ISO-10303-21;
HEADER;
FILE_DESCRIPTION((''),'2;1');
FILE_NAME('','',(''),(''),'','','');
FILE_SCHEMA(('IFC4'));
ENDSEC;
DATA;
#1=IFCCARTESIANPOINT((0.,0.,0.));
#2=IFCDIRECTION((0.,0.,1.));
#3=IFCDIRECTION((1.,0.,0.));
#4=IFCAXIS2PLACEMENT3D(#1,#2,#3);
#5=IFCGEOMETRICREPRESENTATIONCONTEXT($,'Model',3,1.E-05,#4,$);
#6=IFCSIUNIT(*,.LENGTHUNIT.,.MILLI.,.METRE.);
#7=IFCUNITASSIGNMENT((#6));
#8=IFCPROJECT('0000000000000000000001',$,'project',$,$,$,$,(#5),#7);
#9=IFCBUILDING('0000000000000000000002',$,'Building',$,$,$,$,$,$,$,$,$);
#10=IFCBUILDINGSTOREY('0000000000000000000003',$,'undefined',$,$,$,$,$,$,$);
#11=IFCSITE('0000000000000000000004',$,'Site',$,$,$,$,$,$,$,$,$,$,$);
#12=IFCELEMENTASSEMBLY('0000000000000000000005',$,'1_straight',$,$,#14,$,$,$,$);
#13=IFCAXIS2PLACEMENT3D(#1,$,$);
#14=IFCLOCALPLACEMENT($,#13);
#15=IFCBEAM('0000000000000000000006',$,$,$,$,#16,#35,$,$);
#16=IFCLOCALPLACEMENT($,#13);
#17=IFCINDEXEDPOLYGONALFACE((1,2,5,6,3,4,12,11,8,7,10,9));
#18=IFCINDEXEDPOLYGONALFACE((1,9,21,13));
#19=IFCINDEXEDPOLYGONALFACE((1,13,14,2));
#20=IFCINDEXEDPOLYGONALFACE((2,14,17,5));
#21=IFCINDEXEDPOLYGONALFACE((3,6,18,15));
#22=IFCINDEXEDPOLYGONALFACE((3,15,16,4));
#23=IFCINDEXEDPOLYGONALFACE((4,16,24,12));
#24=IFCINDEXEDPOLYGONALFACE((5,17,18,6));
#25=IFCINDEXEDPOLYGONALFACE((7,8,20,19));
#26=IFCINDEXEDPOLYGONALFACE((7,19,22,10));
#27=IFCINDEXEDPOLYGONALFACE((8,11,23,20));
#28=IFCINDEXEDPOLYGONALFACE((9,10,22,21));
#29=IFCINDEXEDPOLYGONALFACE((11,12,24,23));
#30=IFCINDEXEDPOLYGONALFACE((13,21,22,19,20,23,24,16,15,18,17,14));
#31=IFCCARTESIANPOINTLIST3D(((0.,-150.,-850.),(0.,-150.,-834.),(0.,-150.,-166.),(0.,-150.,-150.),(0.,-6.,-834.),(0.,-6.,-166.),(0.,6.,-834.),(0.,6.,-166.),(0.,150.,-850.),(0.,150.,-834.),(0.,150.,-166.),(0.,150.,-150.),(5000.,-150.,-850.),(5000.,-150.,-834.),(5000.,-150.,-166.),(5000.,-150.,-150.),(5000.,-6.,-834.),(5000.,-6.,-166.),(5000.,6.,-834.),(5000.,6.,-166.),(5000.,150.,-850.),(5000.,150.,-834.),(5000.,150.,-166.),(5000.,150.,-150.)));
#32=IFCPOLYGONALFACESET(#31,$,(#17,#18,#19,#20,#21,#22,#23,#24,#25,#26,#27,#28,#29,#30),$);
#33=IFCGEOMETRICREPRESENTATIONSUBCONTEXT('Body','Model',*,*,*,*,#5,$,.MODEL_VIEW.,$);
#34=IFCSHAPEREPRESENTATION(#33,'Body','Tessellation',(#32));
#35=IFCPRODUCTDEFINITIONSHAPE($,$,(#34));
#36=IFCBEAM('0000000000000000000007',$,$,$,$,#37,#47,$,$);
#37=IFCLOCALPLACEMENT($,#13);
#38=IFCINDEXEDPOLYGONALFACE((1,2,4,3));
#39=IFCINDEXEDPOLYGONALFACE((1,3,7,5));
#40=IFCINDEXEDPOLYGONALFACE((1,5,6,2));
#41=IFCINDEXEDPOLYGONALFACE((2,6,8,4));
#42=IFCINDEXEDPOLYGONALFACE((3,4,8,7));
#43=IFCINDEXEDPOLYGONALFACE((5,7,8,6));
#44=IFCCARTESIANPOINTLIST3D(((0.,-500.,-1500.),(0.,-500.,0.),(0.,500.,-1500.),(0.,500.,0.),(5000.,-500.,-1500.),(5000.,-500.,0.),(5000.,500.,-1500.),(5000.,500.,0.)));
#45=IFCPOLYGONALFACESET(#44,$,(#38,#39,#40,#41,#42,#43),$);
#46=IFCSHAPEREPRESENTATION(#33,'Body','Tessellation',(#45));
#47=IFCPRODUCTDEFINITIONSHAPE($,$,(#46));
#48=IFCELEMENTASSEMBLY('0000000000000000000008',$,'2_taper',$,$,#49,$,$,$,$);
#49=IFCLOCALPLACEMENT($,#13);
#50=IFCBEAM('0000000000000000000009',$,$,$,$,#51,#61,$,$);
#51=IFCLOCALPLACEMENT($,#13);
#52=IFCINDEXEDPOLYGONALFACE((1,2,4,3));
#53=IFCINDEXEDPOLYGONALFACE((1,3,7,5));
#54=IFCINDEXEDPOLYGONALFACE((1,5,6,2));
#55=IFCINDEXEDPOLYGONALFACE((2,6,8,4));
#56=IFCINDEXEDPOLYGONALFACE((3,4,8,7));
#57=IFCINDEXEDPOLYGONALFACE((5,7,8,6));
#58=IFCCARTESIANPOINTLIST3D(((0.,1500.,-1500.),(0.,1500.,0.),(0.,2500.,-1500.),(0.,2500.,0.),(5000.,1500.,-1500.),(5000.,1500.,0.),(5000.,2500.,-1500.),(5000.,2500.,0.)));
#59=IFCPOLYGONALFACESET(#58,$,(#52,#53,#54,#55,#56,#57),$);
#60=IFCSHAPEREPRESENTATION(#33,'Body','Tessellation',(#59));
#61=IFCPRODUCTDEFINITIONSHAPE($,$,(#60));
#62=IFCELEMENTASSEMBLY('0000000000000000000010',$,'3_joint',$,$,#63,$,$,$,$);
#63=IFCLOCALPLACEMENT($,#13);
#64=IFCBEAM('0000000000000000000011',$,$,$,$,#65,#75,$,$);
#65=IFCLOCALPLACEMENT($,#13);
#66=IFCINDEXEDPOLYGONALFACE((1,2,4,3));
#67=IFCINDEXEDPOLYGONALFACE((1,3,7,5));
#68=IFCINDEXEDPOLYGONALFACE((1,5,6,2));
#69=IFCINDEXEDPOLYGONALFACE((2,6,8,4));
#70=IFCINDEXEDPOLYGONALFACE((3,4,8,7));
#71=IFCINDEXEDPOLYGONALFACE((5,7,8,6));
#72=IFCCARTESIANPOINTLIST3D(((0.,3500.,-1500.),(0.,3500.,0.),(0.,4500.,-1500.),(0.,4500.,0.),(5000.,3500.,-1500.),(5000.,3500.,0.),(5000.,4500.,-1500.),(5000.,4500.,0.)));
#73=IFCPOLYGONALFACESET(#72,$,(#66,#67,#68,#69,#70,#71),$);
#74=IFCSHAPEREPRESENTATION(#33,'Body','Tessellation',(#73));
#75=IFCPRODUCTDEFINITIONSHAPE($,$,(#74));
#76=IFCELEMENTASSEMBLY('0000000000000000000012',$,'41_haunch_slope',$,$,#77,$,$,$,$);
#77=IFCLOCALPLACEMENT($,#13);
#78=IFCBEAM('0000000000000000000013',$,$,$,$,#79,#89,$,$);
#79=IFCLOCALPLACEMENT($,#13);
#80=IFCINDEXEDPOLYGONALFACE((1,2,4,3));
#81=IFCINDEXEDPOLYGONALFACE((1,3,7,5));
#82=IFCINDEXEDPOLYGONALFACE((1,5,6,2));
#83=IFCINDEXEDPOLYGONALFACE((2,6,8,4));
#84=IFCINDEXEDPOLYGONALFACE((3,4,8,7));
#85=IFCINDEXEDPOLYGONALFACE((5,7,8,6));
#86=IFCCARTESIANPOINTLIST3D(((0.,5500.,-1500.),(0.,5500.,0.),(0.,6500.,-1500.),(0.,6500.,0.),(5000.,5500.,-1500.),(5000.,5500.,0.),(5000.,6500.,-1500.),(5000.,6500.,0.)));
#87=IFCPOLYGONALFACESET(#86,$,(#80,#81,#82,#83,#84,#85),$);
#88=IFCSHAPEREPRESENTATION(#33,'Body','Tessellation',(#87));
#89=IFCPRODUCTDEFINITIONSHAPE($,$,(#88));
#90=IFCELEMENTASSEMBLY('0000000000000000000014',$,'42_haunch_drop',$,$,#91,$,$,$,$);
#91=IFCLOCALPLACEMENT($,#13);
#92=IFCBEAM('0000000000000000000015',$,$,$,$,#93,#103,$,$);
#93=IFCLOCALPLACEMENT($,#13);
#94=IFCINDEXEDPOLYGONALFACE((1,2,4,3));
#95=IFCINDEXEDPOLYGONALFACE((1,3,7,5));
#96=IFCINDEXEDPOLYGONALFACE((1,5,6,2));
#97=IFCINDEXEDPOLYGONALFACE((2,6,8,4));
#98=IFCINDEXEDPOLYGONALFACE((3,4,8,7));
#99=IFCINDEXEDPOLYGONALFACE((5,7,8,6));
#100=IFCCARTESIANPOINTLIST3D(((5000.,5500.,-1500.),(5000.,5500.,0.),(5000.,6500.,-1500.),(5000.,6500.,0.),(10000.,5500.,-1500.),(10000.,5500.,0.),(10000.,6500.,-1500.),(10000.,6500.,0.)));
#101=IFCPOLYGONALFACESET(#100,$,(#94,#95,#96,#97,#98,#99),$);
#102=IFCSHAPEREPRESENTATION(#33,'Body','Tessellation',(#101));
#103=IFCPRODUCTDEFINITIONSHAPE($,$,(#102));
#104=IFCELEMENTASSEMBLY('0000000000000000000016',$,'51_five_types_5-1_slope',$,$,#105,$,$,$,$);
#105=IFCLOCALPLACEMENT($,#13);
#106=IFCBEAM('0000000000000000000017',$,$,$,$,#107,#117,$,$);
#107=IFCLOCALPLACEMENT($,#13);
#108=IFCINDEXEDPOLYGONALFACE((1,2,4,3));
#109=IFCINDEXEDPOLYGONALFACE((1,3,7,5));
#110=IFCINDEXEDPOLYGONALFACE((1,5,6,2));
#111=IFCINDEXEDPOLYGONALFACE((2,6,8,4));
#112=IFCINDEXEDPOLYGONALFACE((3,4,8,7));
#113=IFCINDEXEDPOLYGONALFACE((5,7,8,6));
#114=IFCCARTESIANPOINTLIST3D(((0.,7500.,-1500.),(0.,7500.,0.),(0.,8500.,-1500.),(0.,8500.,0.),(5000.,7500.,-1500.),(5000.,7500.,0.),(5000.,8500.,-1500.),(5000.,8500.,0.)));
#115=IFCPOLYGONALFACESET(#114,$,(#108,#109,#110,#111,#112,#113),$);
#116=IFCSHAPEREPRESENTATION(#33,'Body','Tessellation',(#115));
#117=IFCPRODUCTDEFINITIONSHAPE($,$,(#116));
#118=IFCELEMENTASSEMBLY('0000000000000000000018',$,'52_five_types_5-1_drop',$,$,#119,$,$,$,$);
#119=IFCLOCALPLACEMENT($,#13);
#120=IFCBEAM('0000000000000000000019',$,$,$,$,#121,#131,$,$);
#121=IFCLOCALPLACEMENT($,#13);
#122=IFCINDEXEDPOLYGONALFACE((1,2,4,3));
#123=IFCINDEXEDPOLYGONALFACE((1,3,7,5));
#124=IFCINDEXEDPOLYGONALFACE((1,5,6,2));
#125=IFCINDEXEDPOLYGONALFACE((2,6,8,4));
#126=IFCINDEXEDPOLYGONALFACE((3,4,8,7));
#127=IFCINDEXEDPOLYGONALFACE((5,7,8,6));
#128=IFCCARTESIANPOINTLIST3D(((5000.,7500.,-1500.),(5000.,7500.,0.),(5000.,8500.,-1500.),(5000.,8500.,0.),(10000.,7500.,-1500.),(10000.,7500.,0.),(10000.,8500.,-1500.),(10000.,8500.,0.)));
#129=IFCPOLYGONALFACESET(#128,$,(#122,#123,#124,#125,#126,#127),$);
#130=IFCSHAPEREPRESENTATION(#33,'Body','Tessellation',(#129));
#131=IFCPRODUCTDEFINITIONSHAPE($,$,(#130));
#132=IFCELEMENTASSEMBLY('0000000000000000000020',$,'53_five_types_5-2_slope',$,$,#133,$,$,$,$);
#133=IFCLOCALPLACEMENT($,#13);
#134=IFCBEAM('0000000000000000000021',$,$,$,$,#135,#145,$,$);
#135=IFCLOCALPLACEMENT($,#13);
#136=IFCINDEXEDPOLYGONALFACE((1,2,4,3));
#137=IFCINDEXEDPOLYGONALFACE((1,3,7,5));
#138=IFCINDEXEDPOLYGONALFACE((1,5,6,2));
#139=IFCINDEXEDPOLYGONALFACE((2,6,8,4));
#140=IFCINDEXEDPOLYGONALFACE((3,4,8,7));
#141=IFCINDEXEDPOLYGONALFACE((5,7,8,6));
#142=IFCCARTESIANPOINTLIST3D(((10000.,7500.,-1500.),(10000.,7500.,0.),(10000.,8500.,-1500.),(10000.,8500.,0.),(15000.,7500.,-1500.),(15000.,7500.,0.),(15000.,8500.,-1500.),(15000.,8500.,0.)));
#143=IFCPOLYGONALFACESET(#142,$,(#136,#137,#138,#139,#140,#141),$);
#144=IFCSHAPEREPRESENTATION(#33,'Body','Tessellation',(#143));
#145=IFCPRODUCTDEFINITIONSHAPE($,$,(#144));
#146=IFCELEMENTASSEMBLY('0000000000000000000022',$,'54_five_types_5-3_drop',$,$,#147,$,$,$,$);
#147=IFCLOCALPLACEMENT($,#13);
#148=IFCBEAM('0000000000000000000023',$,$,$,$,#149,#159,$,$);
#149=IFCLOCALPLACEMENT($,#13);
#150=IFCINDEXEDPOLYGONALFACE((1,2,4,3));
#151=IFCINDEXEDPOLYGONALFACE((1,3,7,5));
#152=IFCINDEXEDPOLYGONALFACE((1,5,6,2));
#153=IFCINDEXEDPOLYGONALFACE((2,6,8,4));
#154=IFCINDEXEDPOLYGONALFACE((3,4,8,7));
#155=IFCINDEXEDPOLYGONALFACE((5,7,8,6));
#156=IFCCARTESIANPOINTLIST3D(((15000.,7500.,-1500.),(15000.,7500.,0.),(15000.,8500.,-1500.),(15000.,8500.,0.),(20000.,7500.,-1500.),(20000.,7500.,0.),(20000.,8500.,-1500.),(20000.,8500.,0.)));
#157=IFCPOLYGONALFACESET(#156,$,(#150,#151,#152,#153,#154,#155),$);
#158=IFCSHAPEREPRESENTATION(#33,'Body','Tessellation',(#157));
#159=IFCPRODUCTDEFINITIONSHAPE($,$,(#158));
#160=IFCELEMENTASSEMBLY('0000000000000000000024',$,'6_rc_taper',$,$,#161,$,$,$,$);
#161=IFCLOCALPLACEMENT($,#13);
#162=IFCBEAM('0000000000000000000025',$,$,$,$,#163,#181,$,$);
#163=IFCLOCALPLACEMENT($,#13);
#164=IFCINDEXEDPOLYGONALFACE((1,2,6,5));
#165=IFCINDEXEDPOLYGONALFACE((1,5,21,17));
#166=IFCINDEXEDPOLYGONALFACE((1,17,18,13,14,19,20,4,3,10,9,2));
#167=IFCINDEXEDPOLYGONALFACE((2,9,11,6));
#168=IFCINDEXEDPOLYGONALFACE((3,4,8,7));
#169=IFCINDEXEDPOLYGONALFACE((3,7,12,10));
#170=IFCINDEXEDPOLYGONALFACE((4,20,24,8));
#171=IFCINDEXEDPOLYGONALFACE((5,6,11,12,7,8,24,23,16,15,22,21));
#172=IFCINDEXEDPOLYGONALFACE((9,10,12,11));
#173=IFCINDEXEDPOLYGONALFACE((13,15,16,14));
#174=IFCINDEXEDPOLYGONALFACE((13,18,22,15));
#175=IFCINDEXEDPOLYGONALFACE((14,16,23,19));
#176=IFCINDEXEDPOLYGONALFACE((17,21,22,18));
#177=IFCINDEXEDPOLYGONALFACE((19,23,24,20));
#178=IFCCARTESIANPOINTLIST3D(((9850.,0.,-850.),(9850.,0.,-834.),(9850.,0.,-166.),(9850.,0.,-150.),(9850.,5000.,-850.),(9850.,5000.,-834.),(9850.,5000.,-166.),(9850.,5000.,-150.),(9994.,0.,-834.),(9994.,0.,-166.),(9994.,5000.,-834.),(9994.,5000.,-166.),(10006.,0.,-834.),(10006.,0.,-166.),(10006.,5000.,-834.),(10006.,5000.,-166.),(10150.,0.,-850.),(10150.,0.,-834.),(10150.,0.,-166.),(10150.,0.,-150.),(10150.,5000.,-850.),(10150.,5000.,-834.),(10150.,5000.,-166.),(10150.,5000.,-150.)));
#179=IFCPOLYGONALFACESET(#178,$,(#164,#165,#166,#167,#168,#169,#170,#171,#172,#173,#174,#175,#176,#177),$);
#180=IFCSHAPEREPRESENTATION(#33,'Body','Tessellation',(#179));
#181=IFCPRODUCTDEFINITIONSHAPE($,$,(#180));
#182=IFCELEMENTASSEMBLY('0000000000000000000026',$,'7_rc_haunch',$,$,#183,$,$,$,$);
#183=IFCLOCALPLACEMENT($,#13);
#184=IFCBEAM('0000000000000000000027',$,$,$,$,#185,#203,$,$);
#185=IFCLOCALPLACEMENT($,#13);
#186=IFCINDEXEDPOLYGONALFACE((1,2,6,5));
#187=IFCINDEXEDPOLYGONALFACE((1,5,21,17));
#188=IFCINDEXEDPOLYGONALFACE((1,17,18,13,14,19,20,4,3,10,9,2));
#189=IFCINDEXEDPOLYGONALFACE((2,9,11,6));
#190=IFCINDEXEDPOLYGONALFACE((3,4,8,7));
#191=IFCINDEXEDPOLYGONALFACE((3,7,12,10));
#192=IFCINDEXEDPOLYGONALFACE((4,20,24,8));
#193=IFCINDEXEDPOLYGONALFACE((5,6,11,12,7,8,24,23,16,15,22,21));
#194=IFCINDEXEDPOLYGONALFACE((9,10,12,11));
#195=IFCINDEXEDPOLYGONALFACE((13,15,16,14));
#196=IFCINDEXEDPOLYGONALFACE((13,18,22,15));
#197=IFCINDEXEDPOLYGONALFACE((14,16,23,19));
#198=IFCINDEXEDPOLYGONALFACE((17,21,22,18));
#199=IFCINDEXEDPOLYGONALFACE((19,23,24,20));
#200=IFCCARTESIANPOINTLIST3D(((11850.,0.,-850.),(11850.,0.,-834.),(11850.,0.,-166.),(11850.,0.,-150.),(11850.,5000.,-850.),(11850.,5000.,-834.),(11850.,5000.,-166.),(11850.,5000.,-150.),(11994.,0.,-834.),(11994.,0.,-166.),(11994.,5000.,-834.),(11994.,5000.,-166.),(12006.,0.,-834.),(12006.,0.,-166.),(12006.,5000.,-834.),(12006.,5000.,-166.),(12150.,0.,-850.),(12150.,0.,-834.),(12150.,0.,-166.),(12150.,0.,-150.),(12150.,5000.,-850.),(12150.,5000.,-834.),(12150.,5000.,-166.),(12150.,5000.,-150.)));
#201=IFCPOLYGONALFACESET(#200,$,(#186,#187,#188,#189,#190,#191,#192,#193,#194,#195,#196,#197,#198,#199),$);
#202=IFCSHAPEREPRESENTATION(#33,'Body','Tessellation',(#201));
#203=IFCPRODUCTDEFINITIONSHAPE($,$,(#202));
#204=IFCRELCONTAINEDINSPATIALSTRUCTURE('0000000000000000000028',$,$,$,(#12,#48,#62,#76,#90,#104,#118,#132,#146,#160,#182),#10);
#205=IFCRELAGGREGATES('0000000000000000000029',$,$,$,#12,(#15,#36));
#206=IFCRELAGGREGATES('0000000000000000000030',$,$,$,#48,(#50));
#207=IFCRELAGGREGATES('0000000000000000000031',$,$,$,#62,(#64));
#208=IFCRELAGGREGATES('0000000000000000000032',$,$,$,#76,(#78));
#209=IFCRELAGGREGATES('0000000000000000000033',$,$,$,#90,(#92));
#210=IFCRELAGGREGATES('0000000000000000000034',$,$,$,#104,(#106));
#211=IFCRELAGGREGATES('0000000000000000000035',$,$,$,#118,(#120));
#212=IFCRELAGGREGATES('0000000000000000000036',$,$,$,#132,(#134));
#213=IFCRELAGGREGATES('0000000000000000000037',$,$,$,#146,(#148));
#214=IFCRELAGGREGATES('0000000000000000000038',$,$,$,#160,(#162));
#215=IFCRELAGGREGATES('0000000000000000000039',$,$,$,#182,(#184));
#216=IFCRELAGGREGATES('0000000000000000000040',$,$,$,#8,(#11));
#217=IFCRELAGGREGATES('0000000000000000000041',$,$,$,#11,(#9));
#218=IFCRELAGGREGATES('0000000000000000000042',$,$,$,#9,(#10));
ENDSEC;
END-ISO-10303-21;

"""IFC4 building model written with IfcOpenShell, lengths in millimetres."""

from ifc_helpers import new_model, si_unit, frame, origin_with_axes, place, context, subcontext, project, spatial, rectangle, i_section, extrude, element, aggregate, save


model = new_model("IFC4")

# Units and contexts
model_context = context("Model", 3, precision=1e-05, world=origin_with_axes())
body_context = subcontext(model_context, "Body", "Model", "MODEL_VIEW")
ifc_project = project(units=[si_unit("LENGTHUNIT", "METRE", prefix="MILLI")], contexts=[model_context])

# Site, building, storey
site = spatial("IfcSite", under=ifc_project, Name="Site")
building = spatial("IfcBuilding", under=site, Name="Building")
storey = spatial("IfcBuildingStorey", under=building, Name="undefined")

# Element assembly, beams
assembly_1 = element("IfcElementAssembly", 1, inside=storey, Name="1_straight")
beam_1_placement = place(None, frame((0.0, 0.0, -500.0), z_axis=(1.0, 0.0, 0.0), x_axis=(0.0, 1.0, 0.0)))
beam_1 = element("IfcBeam", 2, at=beam_1_placement, context=body_context, shape_type="SweptSolid", body=[
    extrude(i_section(OverallWidth=300.0, OverallDepth=700.0, WebThickness=12.0, FlangeThickness=16.0, FilletRadius=0.0), origin_with_axes(), (0.0, 0.0, 1.0), 5000.0),
])
beam_2_placement = place(None, frame((0.0, 0.0, -750.0), z_axis=(1.0, 0.0, 0.0), x_axis=(0.0, 1.0, 0.0)))
beam_2 = element("IfcBeam", 3, at=beam_2_placement, context=body_context, shape_type="SweptSolid", body=[
    extrude(rectangle(XDim=1000.0, YDim=1500.0), origin_with_axes(), (0.0, 0.0, 1.0), 5000.0),
])
aggregate(assembly_1, [beam_1, beam_2])

# Element assemblies, beams
assembly_2 = element("IfcElementAssembly", 4, inside=storey, Name="2_taper")
beam_3_placement = place(None, frame((0.0, 2000.0, -750.0), z_axis=(1.0, 0.0, 0.0), x_axis=(0.0, 1.0, 0.0)))
beam_3 = element("IfcBeam", 5, at=beam_3_placement, context=body_context, shape_type="SweptSolid", body=[
    extrude(rectangle(XDim=1000.0, YDim=1500.0), origin_with_axes(), (0.0, 0.0, 1.0), 5000.0),
])
aggregate(assembly_2, [beam_3])
assembly_3 = element("IfcElementAssembly", 6, inside=storey, Name="3_joint")
beam_4_placement = place(None, frame((0.0, 4000.0, -750.0), z_axis=(1.0, 0.0, 0.0), x_axis=(0.0, 1.0, 0.0)))
beam_4 = element("IfcBeam", 7, at=beam_4_placement, context=body_context, shape_type="SweptSolid", body=[
    extrude(rectangle(XDim=1000.0, YDim=1500.0), origin_with_axes(), (0.0, 0.0, 1.0), 5000.0),
])
aggregate(assembly_3, [beam_4])
assembly_4 = element("IfcElementAssembly", 8, inside=storey, Name="41_haunch_slope")
beam_5_placement = place(None, frame((0.0, 6000.0, -750.0), z_axis=(1.0, 0.0, 0.0), x_axis=(0.0, 1.0, 0.0)))
beam_5 = element("IfcBeam", 9, at=beam_5_placement, context=body_context, shape_type="SweptSolid", body=[
    extrude(rectangle(XDim=1000.0, YDim=1500.0), origin_with_axes(), (0.0, 0.0, 1.0), 5000.0),
])
aggregate(assembly_4, [beam_5])
assembly_5 = element("IfcElementAssembly", 10, inside=storey, Name="42_haunch_drop")
beam_6_placement = place(None, frame((5000.0, 6000.0, -750.0), z_axis=(1.0, 0.0, 0.0), x_axis=(0.0, 1.0, 0.0)))
beam_6 = element("IfcBeam", 11, at=beam_6_placement, context=body_context, shape_type="SweptSolid", body=[
    extrude(rectangle(XDim=1000.0, YDim=1500.0), origin_with_axes(), (0.0, 0.0, 1.0), 5000.0),
])
aggregate(assembly_5, [beam_6])
assembly_6 = element("IfcElementAssembly", 12, inside=storey, Name="51_five_types_5-1_slope")
beam_7_placement = place(None, frame((0.0, 8000.0, -750.0), z_axis=(1.0, 0.0, 0.0), x_axis=(0.0, 1.0, 0.0)))
beam_7 = element("IfcBeam", 13, at=beam_7_placement, context=body_context, shape_type="SweptSolid", body=[
    extrude(rectangle(XDim=1000.0, YDim=1500.0), origin_with_axes(), (0.0, 0.0, 1.0), 5000.0),
])
aggregate(assembly_6, [beam_7])
assembly_7 = element("IfcElementAssembly", 14, inside=storey, Name="52_five_types_5-1_drop")
beam_8_placement = place(None, frame((5000.0, 8000.0, -750.0), z_axis=(1.0, 0.0, 0.0), x_axis=(0.0, 1.0, 0.0)))
beam_8 = element("IfcBeam", 15, at=beam_8_placement, context=body_context, shape_type="SweptSolid", body=[
    extrude(rectangle(XDim=1000.0, YDim=1500.0), origin_with_axes(), (0.0, 0.0, 1.0), 5000.0),
])
aggregate(assembly_7, [beam_8])
assembly_8 = element("IfcElementAssembly", 16, inside=storey, Name="53_five_types_5-2_slope")
beam_9_placement = place(None, frame((10000.0, 8000.0, -750.0), z_axis=(1.0, 0.0, 0.0), x_axis=(0.0, 1.0, 0.0)))
beam_9 = element("IfcBeam", 17, at=beam_9_placement, context=body_context, shape_type="SweptSolid", body=[
    extrude(rectangle(XDim=1000.0, YDim=1500.0), origin_with_axes(), (0.0, 0.0, 1.0), 5000.0),
])
aggregate(assembly_8, [beam_9])
assembly_9 = element("IfcElementAssembly", 18, inside=storey, Name="54_five_types_5-3_drop")
beam_10_placement = place(None, frame((15000.0, 8000.0, -750.0), z_axis=(1.0, 0.0, 0.0), x_axis=(0.0, 1.0, 0.0)))
beam_10 = element("IfcBeam", 19, at=beam_10_placement, context=body_context, shape_type="SweptSolid", body=[
    extrude(rectangle(XDim=1000.0, YDim=1500.0), origin_with_axes(), (0.0, 0.0, 1.0), 5000.0),
])
aggregate(assembly_9, [beam_10])
assembly_10 = element("IfcElementAssembly", 20, inside=storey, Name="6_rc_taper")
beam_11_placement = place(None, frame((10000.0, 0.0, -500.0), z_axis=(0.0, 1.0, 0.0), x_axis=(-1.0, 0.0, 0.0)))
beam_11 = element("IfcBeam", 21, at=beam_11_placement, context=body_context, shape_type="SweptSolid", body=[
    extrude(i_section(OverallWidth=300.0, OverallDepth=700.0, WebThickness=12.0, FlangeThickness=16.0, FilletRadius=0.0), origin_with_axes(), (0.0, 0.0, 1.0), 5000.0),
])
aggregate(assembly_10, [beam_11])
assembly_11 = element("IfcElementAssembly", 22, inside=storey, Name="7_rc_haunch")
beam_12_placement = place(None, frame((12000.0, 0.0, -500.0), z_axis=(0.0, 1.0, 0.0), x_axis=(-1.0, 0.0, 0.0)))
beam_12 = element("IfcBeam", 23, at=beam_12_placement, context=body_context, shape_type="SweptSolid", body=[
    extrude(i_section(OverallWidth=300.0, OverallDepth=700.0, WebThickness=12.0, FlangeThickness=16.0, FilletRadius=0.0), origin_with_axes(), (0.0, 0.0, 1.0), 5000.0),
])
aggregate(assembly_11, [beam_12])

save(model, "model.ifc")
